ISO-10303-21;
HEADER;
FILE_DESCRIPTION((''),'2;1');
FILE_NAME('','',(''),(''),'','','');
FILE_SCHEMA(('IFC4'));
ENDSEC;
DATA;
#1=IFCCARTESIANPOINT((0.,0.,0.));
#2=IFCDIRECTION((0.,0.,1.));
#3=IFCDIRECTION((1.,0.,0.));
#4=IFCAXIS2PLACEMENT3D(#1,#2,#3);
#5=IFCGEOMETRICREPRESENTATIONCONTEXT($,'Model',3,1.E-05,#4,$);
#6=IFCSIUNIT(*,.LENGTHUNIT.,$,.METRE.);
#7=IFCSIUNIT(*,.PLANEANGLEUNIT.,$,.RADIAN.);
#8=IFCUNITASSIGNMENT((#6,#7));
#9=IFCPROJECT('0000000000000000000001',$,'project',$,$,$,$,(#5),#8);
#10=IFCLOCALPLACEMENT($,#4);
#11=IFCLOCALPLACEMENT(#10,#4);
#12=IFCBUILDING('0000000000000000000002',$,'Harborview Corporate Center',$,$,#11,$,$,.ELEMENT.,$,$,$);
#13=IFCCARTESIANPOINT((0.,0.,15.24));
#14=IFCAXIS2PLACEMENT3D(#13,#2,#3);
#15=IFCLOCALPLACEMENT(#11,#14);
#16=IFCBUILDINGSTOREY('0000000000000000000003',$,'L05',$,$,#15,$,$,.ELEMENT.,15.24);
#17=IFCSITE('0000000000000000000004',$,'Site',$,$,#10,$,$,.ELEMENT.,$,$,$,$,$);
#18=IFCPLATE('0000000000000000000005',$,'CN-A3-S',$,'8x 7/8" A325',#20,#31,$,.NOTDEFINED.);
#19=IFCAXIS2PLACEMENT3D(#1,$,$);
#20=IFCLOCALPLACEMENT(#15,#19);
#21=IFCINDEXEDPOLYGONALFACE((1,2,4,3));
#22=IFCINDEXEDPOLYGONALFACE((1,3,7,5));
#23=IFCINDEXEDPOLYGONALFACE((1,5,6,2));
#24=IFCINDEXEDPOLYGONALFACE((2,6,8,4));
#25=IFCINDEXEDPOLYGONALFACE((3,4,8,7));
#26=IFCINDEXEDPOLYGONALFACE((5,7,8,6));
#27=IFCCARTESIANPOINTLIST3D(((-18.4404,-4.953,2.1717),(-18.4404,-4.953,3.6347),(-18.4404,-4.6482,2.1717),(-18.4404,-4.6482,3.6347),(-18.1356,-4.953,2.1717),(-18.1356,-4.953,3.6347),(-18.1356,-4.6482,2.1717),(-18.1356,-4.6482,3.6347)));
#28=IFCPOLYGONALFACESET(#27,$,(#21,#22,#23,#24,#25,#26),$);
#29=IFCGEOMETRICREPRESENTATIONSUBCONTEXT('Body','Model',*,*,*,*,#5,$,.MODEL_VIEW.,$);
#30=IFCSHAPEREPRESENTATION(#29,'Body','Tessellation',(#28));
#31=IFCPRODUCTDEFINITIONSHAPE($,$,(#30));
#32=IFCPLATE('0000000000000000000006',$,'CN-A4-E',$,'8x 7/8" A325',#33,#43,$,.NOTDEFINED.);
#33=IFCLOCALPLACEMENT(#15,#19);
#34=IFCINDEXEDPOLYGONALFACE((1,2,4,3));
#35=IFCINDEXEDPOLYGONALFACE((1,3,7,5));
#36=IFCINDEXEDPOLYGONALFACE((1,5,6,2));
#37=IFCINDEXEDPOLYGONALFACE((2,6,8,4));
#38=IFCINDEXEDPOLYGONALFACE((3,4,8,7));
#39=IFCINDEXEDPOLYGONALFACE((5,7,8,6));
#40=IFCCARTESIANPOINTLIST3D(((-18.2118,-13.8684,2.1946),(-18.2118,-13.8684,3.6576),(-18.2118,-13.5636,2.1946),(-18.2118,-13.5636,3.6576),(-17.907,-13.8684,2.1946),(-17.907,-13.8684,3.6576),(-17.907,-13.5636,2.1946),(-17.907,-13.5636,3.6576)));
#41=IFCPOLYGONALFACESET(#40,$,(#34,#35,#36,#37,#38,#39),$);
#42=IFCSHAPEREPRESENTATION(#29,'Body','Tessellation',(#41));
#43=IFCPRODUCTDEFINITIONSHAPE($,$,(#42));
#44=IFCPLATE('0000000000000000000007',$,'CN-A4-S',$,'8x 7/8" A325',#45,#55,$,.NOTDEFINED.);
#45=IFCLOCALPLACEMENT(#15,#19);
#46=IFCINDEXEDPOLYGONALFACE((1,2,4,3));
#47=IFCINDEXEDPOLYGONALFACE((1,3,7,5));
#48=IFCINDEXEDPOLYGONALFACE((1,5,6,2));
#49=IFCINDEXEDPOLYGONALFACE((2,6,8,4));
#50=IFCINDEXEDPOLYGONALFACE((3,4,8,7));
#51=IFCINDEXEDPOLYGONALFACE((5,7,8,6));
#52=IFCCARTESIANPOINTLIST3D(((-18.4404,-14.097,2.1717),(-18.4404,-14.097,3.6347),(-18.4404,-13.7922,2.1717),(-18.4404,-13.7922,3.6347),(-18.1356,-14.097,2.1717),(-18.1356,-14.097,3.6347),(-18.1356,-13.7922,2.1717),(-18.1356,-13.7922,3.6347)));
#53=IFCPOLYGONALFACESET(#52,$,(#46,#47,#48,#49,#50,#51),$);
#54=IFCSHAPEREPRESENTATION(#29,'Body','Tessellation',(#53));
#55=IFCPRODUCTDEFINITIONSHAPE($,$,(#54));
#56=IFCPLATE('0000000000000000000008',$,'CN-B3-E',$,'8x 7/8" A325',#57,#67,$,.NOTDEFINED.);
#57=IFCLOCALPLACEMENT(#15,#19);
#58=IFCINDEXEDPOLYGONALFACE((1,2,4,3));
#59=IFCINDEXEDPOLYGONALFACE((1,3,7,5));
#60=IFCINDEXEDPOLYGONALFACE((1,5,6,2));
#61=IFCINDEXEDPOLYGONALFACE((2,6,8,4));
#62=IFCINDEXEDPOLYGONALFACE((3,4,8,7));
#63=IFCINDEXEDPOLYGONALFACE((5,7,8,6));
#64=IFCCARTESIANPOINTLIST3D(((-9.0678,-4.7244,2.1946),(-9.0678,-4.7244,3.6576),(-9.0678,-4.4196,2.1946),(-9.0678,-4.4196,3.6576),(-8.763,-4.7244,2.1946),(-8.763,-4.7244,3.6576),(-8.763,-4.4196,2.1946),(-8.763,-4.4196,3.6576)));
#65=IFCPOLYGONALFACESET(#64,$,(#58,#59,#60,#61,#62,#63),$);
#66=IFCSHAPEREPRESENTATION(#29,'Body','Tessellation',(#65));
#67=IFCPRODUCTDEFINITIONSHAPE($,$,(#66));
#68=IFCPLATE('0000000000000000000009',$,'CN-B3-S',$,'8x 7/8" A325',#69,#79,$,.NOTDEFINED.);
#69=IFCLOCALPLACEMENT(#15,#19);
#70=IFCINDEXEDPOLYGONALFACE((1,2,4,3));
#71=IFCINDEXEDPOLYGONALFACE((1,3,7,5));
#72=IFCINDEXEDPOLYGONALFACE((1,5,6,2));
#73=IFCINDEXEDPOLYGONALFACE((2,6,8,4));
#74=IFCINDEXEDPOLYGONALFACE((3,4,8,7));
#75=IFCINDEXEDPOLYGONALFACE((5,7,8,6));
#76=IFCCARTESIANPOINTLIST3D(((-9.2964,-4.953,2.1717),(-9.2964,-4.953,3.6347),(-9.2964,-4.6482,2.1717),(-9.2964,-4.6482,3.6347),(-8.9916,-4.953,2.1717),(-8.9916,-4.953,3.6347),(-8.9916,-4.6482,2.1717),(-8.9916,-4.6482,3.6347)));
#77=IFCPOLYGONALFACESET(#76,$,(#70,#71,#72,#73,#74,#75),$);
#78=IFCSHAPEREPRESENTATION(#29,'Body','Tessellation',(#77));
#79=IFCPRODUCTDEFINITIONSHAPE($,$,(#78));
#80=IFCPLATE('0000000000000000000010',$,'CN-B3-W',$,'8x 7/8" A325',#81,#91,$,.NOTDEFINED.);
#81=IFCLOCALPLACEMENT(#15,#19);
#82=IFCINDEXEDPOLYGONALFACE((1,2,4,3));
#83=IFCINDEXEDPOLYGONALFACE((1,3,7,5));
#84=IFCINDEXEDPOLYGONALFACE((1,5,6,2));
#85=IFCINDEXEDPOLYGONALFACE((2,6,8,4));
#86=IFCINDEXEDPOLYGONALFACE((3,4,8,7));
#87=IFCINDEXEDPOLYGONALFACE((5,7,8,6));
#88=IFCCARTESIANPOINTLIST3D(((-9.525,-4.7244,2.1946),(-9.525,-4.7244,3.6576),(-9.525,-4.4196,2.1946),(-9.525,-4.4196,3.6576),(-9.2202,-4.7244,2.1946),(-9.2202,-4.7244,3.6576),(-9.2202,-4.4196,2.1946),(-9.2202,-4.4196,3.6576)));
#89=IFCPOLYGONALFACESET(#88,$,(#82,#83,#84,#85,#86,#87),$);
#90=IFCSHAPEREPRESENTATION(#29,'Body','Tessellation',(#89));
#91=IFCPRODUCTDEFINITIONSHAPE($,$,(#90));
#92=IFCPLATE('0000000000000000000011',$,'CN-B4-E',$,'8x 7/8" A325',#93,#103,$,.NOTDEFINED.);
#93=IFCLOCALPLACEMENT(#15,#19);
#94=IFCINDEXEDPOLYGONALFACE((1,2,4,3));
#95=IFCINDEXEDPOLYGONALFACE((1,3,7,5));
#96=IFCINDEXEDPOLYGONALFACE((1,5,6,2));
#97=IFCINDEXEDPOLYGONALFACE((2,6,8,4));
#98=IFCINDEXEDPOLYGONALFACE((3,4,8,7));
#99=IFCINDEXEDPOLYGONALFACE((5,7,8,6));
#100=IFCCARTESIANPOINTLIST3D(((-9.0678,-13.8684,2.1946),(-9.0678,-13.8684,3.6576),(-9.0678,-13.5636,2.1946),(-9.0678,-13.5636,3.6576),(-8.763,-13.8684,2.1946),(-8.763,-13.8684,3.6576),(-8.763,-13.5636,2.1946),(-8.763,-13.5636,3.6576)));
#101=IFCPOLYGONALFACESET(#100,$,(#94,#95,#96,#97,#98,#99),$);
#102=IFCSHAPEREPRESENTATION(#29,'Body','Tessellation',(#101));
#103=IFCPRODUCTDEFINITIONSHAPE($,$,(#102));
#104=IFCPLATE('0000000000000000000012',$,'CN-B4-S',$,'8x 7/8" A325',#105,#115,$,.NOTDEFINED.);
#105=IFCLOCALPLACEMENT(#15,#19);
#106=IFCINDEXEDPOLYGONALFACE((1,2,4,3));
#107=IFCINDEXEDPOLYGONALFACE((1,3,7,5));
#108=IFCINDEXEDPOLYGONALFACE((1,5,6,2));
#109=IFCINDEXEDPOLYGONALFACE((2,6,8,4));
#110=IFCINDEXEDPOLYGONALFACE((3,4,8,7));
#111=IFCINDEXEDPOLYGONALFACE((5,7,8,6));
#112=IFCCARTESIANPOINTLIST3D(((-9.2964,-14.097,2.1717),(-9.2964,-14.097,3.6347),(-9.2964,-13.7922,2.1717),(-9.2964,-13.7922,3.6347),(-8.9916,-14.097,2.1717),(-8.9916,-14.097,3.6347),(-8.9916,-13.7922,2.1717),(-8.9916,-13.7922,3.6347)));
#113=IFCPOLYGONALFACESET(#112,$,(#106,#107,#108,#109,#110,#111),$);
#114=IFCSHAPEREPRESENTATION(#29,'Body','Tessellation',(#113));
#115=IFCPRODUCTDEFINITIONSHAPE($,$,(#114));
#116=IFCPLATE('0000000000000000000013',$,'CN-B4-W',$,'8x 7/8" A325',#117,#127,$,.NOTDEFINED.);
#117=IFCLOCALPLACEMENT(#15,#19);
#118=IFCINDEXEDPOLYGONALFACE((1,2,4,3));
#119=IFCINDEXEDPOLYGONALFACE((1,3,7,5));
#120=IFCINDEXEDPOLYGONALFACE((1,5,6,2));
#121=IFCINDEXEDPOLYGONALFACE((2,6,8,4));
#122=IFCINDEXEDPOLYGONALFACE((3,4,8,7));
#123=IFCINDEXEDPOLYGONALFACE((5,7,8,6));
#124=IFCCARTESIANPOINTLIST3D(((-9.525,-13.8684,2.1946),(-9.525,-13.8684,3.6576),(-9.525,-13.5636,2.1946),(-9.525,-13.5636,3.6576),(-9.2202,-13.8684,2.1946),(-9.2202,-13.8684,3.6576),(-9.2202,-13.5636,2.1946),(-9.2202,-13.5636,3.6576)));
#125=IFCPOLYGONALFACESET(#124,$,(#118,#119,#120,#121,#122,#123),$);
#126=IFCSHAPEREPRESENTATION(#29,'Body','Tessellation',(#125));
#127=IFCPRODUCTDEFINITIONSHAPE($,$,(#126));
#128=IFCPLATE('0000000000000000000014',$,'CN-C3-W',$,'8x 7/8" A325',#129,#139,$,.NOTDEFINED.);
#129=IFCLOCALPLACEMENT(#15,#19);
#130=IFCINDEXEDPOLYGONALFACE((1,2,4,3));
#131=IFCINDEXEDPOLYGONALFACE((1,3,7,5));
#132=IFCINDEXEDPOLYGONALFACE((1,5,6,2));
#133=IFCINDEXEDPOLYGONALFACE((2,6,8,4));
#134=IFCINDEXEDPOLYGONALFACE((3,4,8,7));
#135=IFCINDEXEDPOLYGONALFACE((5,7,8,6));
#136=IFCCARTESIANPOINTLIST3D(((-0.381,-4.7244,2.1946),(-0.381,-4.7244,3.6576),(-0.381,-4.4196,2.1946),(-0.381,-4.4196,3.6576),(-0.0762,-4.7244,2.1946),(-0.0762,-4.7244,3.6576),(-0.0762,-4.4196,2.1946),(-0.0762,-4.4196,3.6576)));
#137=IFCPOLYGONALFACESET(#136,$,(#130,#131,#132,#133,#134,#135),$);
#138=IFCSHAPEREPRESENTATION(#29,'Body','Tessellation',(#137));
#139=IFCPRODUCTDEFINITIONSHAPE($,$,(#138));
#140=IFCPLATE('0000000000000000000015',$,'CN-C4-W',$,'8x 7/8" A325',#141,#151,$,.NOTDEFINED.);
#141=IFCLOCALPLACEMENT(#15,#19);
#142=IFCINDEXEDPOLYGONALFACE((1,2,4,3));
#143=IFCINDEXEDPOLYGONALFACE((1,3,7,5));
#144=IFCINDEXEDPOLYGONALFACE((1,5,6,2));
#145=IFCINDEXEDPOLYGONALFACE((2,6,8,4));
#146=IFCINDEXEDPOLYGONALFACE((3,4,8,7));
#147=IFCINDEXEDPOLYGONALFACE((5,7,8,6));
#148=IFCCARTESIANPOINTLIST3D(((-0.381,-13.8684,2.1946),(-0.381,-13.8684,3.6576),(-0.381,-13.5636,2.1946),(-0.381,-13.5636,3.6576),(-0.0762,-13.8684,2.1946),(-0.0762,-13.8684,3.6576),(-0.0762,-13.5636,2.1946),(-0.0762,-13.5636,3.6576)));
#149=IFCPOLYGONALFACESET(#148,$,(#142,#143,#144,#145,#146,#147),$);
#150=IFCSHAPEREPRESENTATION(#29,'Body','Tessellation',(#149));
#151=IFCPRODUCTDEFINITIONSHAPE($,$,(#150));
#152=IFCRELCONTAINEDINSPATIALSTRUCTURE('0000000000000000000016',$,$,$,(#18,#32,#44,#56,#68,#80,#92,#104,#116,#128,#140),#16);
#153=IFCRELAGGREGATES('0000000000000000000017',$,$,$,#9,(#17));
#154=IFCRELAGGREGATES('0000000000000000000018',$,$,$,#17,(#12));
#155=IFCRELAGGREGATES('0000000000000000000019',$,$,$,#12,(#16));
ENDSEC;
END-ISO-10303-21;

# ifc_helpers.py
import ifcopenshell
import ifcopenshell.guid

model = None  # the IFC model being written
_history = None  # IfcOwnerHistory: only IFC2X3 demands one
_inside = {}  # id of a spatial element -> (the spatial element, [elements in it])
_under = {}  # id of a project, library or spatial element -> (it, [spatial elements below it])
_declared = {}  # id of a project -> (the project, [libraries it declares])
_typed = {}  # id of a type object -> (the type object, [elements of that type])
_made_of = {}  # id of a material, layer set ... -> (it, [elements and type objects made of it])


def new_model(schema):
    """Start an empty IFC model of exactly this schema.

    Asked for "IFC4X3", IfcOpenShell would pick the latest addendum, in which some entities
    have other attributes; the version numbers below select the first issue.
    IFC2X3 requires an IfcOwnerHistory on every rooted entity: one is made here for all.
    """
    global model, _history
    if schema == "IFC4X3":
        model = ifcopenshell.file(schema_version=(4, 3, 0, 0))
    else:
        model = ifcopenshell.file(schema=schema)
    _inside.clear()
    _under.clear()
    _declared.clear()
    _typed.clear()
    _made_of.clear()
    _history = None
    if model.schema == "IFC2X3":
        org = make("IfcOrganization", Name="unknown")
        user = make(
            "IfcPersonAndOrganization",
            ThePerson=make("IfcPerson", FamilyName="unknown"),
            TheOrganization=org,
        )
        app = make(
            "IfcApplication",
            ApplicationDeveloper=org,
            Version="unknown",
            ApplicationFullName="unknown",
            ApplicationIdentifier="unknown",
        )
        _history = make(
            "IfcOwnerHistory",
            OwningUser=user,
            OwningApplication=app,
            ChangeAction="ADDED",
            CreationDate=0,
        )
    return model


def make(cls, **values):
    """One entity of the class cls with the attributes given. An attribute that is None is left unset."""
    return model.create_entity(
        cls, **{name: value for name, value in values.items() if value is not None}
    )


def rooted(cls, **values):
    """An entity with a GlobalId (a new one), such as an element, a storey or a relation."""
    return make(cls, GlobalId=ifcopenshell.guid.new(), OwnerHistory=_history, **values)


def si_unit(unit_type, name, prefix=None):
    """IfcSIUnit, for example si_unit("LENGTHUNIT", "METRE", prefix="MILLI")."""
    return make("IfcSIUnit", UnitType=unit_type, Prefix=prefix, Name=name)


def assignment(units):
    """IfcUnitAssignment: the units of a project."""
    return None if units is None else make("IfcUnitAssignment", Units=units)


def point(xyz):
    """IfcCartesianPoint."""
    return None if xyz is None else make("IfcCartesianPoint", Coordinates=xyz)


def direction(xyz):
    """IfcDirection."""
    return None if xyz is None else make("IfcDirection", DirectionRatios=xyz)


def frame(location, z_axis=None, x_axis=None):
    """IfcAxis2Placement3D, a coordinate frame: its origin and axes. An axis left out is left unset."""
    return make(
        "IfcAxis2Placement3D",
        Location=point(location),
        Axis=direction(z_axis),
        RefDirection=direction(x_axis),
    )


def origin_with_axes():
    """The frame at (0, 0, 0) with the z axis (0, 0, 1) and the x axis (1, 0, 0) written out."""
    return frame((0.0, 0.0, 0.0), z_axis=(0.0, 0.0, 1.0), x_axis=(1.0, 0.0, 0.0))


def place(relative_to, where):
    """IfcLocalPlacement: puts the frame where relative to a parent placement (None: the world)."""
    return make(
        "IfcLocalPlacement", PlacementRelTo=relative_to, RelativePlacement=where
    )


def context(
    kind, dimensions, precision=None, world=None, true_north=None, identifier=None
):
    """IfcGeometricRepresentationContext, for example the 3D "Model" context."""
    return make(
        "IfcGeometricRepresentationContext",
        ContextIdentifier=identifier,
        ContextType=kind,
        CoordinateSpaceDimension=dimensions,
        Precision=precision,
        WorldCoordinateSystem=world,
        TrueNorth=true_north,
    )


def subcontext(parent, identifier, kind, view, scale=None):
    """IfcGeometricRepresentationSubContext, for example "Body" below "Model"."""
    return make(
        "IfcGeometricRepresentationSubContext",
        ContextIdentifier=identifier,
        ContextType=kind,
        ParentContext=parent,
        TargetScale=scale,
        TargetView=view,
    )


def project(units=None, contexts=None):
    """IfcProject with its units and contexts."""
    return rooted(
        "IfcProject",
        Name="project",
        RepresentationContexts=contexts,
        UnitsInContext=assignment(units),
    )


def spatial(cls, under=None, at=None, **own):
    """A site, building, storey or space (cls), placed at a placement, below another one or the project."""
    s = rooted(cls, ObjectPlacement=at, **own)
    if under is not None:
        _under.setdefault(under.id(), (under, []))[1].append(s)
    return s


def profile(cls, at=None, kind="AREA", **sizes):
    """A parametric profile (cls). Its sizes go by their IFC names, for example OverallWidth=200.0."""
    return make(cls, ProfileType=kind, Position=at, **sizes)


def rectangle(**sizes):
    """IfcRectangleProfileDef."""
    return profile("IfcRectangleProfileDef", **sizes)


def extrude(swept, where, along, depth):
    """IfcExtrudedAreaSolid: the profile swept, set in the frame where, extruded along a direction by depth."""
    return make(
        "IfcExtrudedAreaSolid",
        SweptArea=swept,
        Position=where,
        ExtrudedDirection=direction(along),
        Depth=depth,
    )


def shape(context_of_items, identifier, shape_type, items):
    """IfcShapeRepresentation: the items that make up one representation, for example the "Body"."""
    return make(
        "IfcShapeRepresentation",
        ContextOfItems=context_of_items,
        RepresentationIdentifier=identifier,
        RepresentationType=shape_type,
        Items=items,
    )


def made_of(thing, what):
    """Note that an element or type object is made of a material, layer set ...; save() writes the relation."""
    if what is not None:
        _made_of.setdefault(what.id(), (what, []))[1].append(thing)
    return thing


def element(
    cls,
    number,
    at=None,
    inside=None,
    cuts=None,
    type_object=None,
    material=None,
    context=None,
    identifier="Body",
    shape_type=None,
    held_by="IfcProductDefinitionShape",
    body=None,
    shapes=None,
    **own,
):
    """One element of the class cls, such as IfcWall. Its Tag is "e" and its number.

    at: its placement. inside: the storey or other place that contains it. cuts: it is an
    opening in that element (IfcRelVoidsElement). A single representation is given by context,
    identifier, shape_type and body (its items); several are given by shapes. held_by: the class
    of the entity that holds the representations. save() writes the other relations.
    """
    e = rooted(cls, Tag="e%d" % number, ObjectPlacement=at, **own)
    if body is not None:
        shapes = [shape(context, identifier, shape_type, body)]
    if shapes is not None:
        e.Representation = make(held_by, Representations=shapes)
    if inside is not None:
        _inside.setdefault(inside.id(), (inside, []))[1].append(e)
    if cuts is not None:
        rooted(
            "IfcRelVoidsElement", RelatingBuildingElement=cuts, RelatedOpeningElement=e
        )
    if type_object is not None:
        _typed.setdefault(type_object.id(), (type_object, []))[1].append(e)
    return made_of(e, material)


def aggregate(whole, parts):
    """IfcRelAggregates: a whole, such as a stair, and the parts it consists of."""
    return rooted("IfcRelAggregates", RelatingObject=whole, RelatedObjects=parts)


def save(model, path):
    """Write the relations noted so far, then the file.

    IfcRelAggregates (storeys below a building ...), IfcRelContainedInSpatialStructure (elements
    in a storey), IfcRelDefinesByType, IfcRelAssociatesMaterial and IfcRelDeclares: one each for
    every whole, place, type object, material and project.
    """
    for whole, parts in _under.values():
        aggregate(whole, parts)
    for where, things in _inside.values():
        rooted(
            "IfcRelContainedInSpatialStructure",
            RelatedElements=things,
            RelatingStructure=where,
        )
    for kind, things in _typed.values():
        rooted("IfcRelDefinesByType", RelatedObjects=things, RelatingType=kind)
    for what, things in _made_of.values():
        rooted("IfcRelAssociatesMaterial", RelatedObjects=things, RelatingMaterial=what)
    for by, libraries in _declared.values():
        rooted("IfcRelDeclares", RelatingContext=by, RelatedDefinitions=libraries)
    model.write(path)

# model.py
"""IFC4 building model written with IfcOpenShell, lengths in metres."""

from ifc_helpers import new_model, si_unit, frame, origin_with_axes, place, context, subcontext, project, spatial, rectangle, extrude, element, save


model = new_model("IFC4")

# Units and contexts
model_context = context("Model", 3, precision=1e-05, world=origin_with_axes())
body_context = subcontext(model_context, "Body", "Model", "MODEL_VIEW")
ifc_project = project(units=[si_unit("LENGTHUNIT", "METRE"), si_unit("PLANEANGLEUNIT", "RADIAN")], contexts=[model_context])

# Site, building, storey
site_placement = place(None, origin_with_axes())
site = spatial("IfcSite", under=ifc_project, at=site_placement, Name="Site", CompositionType="ELEMENT")
building_placement = place(site_placement, origin_with_axes())
building = spatial("IfcBuilding", under=site, at=building_placement, Name="Harborview Corporate Center", CompositionType="ELEMENT")
storey_placement = place(building_placement, frame((0.0, 0.0, 15.24), z_axis=(0.0, 0.0, 1.0), x_axis=(1.0, 0.0, 0.0)))
storey = spatial("IfcBuildingStorey", under=building, at=storey_placement, Name="L05", CompositionType="ELEMENT", Elevation=15.24)

# Plates
for number, where, z_axis, x_axis, name in (
    (1, (-18.288, -4.8006, 2.1717), (0.0, 0.0, 1.0), (1.0, 0.0, 0.0), "CN-A3-S"),
    (2, (-18.0594, -13.716, 2.1946), (0.0, 0.0, 1.0), (1.0, 0.0, 0.0), "CN-A4-E"),
    (3, (-18.288, -13.9446, 2.1717), (0.0, 0.0, 1.0), (1.0, 0.0, 0.0), "CN-A4-S"),
    (4, (-8.9154, -4.572, 2.1946), (0.0, 0.0, 1.0), (1.0, 0.0, 0.0), "CN-B3-E"),
    (5, (-9.144, -4.8006, 2.1717), (0.0, 0.0, 1.0), (1.0, 0.0, 0.0), "CN-B3-S"),
    (6, (-9.3726, -4.572, 2.1946), (0.0, 0.0, 1.0), (1.0, 0.0, 0.0), "CN-B3-W"),
    (7, (-8.9154, -13.716, 2.1946), (0.0, 0.0, 1.0), (1.0, 0.0, 0.0), "CN-B4-E"),
    (8, (-9.144, -13.9446, 2.1717), (0.0, 0.0, 1.0), (1.0, 0.0, 0.0), "CN-B4-S"),
    (9, (-9.3726, -13.716, 2.1946), (0.0, 0.0, 1.0), (1.0, 0.0, 0.0), "CN-B4-W"),
):
    element("IfcPlate", number, at=place(storey_placement, frame(where, z_axis=z_axis, x_axis=x_axis)), inside=storey, Name=name, ObjectType="8x 7/8\" A325", PredefinedType="NOTDEFINED", context=body_context, shape_type="SweptSolid", body=[
        extrude(rectangle(XDim=0.3048, YDim=0.3048), origin_with_axes(), (0.0, 0.0, 1.0), 1.463),
    ])
for number, where, z_axis, x_axis, name in (
    (10, (-0.2286, -4.572, 2.1946), (0.0, 0.0, 1.0), (1.0, 0.0, 0.0), "CN-C3-W"),
    (11, (-0.2286, -13.716, 2.1946), (0.0, 0.0, 1.0), (1.0, 0.0, 0.0), "CN-C4-W"),
):
    element("IfcPlate", number, at=place(storey_placement, frame(where, z_axis=z_axis, x_axis=x_axis)), inside=storey, Name=name, ObjectType="8x 7/8\" A325", PredefinedType="NOTDEFINED", context=body_context, shape_type="SweptSolid", body=[
        extrude(rectangle(XDim=0.3048, YDim=0.3048), origin_with_axes(), (0.0, 0.0, 1.0), 1.463),
    ])

save(model, "model.ifc")
